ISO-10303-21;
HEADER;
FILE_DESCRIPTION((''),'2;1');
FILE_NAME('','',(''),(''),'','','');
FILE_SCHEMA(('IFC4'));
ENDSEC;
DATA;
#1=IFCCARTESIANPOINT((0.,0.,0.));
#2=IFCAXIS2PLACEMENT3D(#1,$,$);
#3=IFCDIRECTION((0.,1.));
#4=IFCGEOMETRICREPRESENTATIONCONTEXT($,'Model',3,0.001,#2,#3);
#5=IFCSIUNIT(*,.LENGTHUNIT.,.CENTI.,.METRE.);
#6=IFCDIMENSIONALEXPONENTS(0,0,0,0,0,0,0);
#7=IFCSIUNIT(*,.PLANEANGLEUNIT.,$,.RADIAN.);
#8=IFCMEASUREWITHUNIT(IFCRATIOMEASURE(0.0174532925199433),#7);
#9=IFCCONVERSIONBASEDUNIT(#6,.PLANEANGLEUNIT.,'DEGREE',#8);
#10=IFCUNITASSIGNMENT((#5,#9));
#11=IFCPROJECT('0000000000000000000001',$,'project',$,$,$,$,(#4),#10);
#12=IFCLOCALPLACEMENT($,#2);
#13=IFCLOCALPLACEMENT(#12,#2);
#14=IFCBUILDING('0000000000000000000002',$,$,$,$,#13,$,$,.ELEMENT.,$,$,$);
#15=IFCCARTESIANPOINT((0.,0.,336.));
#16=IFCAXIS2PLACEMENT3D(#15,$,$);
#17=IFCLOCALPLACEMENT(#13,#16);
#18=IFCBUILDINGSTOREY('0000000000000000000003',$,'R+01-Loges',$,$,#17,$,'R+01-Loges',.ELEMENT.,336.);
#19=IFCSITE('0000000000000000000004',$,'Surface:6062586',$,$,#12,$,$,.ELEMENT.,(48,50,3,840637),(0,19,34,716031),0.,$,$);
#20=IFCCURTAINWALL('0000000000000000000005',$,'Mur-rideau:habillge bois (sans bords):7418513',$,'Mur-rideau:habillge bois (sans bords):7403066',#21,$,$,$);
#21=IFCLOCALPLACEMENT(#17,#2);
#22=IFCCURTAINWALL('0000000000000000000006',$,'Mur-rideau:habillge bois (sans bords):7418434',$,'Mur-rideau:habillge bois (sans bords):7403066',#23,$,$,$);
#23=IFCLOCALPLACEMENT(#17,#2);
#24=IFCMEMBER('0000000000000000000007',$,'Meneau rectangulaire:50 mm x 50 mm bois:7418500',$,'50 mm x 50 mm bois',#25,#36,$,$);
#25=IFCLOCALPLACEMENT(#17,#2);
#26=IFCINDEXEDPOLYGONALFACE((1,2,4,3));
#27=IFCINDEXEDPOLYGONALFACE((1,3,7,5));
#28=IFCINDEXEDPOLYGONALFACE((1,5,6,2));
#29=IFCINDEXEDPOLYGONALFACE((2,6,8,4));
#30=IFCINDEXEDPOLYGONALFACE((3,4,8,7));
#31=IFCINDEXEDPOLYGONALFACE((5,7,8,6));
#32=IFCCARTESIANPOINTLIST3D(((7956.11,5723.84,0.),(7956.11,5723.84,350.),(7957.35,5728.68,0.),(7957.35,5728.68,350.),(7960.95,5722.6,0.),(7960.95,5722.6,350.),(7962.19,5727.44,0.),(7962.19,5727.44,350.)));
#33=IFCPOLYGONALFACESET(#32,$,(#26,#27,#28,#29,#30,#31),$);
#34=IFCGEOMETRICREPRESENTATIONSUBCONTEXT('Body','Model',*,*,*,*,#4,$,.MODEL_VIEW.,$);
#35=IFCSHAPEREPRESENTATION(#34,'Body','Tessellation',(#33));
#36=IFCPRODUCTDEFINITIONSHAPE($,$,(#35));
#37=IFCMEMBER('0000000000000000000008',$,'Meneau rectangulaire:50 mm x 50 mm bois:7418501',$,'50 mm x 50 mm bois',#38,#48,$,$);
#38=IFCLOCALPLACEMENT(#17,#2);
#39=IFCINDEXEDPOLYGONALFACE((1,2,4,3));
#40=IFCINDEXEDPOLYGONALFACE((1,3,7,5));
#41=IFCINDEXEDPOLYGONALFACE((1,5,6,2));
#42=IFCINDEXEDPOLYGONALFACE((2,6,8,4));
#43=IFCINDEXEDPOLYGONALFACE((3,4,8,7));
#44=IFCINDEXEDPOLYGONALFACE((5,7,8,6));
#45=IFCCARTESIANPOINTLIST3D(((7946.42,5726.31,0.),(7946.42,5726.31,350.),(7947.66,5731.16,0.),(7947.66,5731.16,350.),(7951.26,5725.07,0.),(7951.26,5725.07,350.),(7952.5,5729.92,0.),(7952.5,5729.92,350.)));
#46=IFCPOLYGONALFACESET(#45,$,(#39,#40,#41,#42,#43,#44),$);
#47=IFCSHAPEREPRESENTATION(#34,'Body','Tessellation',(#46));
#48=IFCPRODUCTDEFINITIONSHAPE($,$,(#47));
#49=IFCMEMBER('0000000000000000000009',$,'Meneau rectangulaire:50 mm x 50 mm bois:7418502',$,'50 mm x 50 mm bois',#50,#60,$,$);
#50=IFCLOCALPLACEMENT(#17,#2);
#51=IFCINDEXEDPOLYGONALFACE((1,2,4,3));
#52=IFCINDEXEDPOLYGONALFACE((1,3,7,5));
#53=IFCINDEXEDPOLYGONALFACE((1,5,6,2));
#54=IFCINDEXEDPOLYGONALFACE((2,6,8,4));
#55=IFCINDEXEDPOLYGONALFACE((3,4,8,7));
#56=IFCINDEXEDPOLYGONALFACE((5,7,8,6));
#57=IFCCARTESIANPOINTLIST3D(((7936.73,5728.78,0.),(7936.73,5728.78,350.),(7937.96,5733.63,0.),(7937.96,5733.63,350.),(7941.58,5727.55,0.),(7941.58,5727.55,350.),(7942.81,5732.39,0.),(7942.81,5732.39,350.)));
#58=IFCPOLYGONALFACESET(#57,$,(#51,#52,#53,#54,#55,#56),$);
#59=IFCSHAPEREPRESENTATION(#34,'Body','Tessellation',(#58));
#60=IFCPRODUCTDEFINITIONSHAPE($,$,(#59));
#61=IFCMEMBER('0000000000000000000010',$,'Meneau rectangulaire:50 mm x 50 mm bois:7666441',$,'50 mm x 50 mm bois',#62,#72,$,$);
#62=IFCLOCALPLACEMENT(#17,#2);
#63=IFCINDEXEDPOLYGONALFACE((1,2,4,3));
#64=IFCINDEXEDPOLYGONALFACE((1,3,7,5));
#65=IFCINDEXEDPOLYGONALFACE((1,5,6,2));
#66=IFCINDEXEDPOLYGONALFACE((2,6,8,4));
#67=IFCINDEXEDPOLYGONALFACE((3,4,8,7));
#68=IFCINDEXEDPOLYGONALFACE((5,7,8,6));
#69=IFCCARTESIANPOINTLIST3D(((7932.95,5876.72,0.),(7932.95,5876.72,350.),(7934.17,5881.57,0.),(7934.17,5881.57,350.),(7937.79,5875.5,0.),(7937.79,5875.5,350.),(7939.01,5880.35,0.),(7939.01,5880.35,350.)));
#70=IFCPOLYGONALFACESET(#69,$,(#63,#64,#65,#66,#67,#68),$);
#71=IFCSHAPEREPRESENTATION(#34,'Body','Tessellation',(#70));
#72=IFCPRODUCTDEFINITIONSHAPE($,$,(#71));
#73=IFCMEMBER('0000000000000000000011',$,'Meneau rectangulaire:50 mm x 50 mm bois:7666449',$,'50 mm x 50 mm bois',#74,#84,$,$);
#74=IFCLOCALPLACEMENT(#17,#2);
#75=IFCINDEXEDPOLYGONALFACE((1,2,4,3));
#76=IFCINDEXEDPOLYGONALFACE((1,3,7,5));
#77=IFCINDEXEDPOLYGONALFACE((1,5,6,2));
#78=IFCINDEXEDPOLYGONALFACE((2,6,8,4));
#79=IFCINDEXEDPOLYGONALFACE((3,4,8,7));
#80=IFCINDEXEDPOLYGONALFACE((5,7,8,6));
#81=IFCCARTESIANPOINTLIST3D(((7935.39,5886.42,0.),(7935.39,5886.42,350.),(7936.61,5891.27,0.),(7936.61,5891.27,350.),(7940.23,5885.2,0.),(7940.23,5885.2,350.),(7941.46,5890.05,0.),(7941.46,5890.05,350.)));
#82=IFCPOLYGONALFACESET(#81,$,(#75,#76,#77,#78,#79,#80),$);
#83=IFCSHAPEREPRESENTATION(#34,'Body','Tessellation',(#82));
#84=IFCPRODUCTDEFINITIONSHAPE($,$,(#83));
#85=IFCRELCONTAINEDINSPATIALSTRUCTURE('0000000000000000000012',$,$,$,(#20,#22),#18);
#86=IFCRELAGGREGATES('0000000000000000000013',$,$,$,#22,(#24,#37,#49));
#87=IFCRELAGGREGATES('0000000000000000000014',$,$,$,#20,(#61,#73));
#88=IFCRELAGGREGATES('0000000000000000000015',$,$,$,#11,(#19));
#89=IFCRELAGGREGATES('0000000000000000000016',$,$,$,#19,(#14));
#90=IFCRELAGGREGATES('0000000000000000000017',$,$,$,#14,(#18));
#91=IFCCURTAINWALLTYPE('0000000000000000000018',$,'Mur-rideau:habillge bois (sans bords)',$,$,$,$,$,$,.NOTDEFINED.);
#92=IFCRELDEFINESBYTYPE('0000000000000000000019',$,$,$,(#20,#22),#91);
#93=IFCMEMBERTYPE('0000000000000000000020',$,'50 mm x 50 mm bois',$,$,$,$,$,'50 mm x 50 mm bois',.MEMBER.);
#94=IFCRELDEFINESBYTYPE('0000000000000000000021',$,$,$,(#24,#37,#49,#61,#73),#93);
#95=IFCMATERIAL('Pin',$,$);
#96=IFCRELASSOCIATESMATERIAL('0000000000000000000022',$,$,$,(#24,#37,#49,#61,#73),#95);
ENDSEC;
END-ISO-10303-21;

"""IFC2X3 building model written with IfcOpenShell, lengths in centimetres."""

from ifc_helpers import new_model, entity, si_unit, converted_unit, direction, frame, origin, origin_2d_with_axis, place, context, subcontext, project, spatial, rectangle, extrude, source, transform, mapped, material, type_object, type_shapes, element, aggregate, save


model = new_model("IFC2X3")

# Units and contexts
model_context = context("Model", 3, precision=0.001, world=origin(), true_north=direction((0.0, 1.0)))
body_context = subcontext(model_context, "Body", "Model", "MODEL_VIEW")
ifc_project = project(units=[si_unit("LENGTHUNIT", "METRE", prefix="CENTI"), converted_unit("PLANEANGLEUNIT", "DEGREE", entity("IfcRatioMeasure", 0.0174532925199433), si_unit("PLANEANGLEUNIT", "RADIAN"), dimensions=[0, 0, 0, 0, 0, 0, 0])], contexts=[model_context])

# Site, building, storey
site_placement = place(None, origin())
site = spatial("IfcSite", under=ifc_project, at=site_placement, Name="Surface:6062586", CompositionType="ELEMENT", RefLatitude=(48, 50, 3, 840637), RefLongitude=(0, 19, 34, 716031), RefElevation=0.0)
building_placement = place(site_placement, origin())
building = spatial("IfcBuilding", under=site, at=building_placement, CompositionType="ELEMENT")
storey_placement = place(building_placement, frame((0.0, 0.0, 336.0)))
storey = spatial("IfcBuildingStorey", under=building, at=storey_placement, Name="R+01-Loges", LongName="R+01-Loges", CompositionType="ELEMENT", Elevation=336.0)

# Curtain wall
curtain_wall_type = type_object("IfcCurtainWallType", Name="Mur-rideau:habillge bois (sans bords)", PredefinedType="NOTDEFINED")
curtain_wall_1_placement = place(storey_placement, frame((0.0, 0.0, -336.0)))
curtain_wall_1 = element("IfcCurtainWall", 1, at=curtain_wall_1_placement, inside=storey, type_object=curtain_wall_type, Name="Mur-rideau:habillge bois (sans bords):7418513", ObjectType="Mur-rideau:habillge bois (sans bords):7403066")
ifc_material = material(Name="Pin")

# Curtain wall, members
curtain_wall_2_placement = place(storey_placement, frame((0.0, 0.0, -336.0)))
curtain_wall_2 = element("IfcCurtainWall", 2, at=curtain_wall_2_placement, inside=storey, type_object=curtain_wall_type, Name="Mur-rideau:habillge bois (sans bords):7418434", ObjectType="Mur-rideau:habillge bois (sans bords):7403066")
member_type_1 = type_object("IfcMemberType", Name="50 mm x 50 mm bois", ElementType="50 mm x 50 mm bois", PredefinedType="MEMBER")
shared_shape_1 = source(origin(), body_context, "Body", "SweptSolid", [
    extrude(rectangle(XDim=5.0, YDim=5.0, at=origin_2d_with_axis()), frame((0.0, 0.0, -350.0), z_axis=(0.0, 0.0, 1.0), x_axis=(0.0, -1.0, 0.0)), (0.0, 0.0, 1.0), 350.0),
])
type_shapes(member_type_1, [shared_shape_1])
member_1_placement = place(storey_placement, frame((7959.15, 5725.64, 0.0), z_axis=(0.0, 0.0, -1.0), x_axis=(-0.968721, 0.248151, 0.0)))
member_1 = element("IfcMember", 3, at=member_1_placement, type_object=member_type_1, material=ifc_material, Name="Meneau rectangulaire:50 mm x 50 mm bois:7418500", ObjectType="50 mm x 50 mm bois", context=body_context, shape_type="MappedRepresentation", body=[
    mapped(shared_shape_1, transform((0.0, 0.0, 0.0), scale=1.0)),
])
member_2_placement = place(storey_placement, frame((7949.46, 5728.12, 0.0), z_axis=(0.0, 0.0, -1.0), x_axis=(-0.968904, 0.247438, 0.0)))
member_2 = element("IfcMember", 4, at=member_2_placement, type_object=member_type_1, material=ifc_material, Name="Meneau rectangulaire:50 mm x 50 mm bois:7418501", ObjectType="50 mm x 50 mm bois", context=body_context, shape_type="MappedRepresentation", body=[
    mapped(shared_shape_1, transform((0.0, 0.0, 0.0), scale=1.0)),
])
member_3_placement = place(storey_placement, frame((7939.77, 5730.59, 0.0), z_axis=(0.0, 0.0, -1.0), x_axis=(-0.969086, 0.246725, 0.0)))
member_3 = element("IfcMember", 5, at=member_3_placement, type_object=member_type_1, material=ifc_material, Name="Meneau rectangulaire:50 mm x 50 mm bois:7418502", ObjectType="50 mm x 50 mm bois", context=body_context, shape_type="MappedRepresentation", body=[
    mapped(shared_shape_1, transform((0.0, 0.0, 0.0), scale=1.0)),
])
aggregate(curtain_wall_2, [member_1, member_2, member_3])

# Members
member_4_placement = place(storey_placement, frame((7935.98, 5878.54, 0.0), z_axis=(0.0, 0.0, -1.0), x_axis=(0.244071, 0.969757, 0.0)))
member_4 = element("IfcMember", 6, at=member_4_placement, type_object=member_type_1, material=ifc_material, Name="Meneau rectangulaire:50 mm x 50 mm bois:7666441", ObjectType="50 mm x 50 mm bois", context=body_context, shape_type="MappedRepresentation", body=[
    mapped(shared_shape_1, transform((0.0, 0.0, 0.0), scale=1.0)),
])
member_5_placement = place(storey_placement, frame((7938.42, 5888.23, 0.0), z_axis=(0.0, 0.0, -1.0), x_axis=(0.244071, 0.969757, 0.0)))
member_5 = element("IfcMember", 7, at=member_5_placement, type_object=member_type_1, material=ifc_material, Name="Meneau rectangulaire:50 mm x 50 mm bois:7666449", ObjectType="50 mm x 50 mm bois", context=body_context, shape_type="MappedRepresentation", body=[
    mapped(shared_shape_1, transform((0.0, 0.0, 0.0), scale=1.0)),
])
aggregate(curtain_wall_1, [member_4, member_5])

save(model, "model.ifc")
